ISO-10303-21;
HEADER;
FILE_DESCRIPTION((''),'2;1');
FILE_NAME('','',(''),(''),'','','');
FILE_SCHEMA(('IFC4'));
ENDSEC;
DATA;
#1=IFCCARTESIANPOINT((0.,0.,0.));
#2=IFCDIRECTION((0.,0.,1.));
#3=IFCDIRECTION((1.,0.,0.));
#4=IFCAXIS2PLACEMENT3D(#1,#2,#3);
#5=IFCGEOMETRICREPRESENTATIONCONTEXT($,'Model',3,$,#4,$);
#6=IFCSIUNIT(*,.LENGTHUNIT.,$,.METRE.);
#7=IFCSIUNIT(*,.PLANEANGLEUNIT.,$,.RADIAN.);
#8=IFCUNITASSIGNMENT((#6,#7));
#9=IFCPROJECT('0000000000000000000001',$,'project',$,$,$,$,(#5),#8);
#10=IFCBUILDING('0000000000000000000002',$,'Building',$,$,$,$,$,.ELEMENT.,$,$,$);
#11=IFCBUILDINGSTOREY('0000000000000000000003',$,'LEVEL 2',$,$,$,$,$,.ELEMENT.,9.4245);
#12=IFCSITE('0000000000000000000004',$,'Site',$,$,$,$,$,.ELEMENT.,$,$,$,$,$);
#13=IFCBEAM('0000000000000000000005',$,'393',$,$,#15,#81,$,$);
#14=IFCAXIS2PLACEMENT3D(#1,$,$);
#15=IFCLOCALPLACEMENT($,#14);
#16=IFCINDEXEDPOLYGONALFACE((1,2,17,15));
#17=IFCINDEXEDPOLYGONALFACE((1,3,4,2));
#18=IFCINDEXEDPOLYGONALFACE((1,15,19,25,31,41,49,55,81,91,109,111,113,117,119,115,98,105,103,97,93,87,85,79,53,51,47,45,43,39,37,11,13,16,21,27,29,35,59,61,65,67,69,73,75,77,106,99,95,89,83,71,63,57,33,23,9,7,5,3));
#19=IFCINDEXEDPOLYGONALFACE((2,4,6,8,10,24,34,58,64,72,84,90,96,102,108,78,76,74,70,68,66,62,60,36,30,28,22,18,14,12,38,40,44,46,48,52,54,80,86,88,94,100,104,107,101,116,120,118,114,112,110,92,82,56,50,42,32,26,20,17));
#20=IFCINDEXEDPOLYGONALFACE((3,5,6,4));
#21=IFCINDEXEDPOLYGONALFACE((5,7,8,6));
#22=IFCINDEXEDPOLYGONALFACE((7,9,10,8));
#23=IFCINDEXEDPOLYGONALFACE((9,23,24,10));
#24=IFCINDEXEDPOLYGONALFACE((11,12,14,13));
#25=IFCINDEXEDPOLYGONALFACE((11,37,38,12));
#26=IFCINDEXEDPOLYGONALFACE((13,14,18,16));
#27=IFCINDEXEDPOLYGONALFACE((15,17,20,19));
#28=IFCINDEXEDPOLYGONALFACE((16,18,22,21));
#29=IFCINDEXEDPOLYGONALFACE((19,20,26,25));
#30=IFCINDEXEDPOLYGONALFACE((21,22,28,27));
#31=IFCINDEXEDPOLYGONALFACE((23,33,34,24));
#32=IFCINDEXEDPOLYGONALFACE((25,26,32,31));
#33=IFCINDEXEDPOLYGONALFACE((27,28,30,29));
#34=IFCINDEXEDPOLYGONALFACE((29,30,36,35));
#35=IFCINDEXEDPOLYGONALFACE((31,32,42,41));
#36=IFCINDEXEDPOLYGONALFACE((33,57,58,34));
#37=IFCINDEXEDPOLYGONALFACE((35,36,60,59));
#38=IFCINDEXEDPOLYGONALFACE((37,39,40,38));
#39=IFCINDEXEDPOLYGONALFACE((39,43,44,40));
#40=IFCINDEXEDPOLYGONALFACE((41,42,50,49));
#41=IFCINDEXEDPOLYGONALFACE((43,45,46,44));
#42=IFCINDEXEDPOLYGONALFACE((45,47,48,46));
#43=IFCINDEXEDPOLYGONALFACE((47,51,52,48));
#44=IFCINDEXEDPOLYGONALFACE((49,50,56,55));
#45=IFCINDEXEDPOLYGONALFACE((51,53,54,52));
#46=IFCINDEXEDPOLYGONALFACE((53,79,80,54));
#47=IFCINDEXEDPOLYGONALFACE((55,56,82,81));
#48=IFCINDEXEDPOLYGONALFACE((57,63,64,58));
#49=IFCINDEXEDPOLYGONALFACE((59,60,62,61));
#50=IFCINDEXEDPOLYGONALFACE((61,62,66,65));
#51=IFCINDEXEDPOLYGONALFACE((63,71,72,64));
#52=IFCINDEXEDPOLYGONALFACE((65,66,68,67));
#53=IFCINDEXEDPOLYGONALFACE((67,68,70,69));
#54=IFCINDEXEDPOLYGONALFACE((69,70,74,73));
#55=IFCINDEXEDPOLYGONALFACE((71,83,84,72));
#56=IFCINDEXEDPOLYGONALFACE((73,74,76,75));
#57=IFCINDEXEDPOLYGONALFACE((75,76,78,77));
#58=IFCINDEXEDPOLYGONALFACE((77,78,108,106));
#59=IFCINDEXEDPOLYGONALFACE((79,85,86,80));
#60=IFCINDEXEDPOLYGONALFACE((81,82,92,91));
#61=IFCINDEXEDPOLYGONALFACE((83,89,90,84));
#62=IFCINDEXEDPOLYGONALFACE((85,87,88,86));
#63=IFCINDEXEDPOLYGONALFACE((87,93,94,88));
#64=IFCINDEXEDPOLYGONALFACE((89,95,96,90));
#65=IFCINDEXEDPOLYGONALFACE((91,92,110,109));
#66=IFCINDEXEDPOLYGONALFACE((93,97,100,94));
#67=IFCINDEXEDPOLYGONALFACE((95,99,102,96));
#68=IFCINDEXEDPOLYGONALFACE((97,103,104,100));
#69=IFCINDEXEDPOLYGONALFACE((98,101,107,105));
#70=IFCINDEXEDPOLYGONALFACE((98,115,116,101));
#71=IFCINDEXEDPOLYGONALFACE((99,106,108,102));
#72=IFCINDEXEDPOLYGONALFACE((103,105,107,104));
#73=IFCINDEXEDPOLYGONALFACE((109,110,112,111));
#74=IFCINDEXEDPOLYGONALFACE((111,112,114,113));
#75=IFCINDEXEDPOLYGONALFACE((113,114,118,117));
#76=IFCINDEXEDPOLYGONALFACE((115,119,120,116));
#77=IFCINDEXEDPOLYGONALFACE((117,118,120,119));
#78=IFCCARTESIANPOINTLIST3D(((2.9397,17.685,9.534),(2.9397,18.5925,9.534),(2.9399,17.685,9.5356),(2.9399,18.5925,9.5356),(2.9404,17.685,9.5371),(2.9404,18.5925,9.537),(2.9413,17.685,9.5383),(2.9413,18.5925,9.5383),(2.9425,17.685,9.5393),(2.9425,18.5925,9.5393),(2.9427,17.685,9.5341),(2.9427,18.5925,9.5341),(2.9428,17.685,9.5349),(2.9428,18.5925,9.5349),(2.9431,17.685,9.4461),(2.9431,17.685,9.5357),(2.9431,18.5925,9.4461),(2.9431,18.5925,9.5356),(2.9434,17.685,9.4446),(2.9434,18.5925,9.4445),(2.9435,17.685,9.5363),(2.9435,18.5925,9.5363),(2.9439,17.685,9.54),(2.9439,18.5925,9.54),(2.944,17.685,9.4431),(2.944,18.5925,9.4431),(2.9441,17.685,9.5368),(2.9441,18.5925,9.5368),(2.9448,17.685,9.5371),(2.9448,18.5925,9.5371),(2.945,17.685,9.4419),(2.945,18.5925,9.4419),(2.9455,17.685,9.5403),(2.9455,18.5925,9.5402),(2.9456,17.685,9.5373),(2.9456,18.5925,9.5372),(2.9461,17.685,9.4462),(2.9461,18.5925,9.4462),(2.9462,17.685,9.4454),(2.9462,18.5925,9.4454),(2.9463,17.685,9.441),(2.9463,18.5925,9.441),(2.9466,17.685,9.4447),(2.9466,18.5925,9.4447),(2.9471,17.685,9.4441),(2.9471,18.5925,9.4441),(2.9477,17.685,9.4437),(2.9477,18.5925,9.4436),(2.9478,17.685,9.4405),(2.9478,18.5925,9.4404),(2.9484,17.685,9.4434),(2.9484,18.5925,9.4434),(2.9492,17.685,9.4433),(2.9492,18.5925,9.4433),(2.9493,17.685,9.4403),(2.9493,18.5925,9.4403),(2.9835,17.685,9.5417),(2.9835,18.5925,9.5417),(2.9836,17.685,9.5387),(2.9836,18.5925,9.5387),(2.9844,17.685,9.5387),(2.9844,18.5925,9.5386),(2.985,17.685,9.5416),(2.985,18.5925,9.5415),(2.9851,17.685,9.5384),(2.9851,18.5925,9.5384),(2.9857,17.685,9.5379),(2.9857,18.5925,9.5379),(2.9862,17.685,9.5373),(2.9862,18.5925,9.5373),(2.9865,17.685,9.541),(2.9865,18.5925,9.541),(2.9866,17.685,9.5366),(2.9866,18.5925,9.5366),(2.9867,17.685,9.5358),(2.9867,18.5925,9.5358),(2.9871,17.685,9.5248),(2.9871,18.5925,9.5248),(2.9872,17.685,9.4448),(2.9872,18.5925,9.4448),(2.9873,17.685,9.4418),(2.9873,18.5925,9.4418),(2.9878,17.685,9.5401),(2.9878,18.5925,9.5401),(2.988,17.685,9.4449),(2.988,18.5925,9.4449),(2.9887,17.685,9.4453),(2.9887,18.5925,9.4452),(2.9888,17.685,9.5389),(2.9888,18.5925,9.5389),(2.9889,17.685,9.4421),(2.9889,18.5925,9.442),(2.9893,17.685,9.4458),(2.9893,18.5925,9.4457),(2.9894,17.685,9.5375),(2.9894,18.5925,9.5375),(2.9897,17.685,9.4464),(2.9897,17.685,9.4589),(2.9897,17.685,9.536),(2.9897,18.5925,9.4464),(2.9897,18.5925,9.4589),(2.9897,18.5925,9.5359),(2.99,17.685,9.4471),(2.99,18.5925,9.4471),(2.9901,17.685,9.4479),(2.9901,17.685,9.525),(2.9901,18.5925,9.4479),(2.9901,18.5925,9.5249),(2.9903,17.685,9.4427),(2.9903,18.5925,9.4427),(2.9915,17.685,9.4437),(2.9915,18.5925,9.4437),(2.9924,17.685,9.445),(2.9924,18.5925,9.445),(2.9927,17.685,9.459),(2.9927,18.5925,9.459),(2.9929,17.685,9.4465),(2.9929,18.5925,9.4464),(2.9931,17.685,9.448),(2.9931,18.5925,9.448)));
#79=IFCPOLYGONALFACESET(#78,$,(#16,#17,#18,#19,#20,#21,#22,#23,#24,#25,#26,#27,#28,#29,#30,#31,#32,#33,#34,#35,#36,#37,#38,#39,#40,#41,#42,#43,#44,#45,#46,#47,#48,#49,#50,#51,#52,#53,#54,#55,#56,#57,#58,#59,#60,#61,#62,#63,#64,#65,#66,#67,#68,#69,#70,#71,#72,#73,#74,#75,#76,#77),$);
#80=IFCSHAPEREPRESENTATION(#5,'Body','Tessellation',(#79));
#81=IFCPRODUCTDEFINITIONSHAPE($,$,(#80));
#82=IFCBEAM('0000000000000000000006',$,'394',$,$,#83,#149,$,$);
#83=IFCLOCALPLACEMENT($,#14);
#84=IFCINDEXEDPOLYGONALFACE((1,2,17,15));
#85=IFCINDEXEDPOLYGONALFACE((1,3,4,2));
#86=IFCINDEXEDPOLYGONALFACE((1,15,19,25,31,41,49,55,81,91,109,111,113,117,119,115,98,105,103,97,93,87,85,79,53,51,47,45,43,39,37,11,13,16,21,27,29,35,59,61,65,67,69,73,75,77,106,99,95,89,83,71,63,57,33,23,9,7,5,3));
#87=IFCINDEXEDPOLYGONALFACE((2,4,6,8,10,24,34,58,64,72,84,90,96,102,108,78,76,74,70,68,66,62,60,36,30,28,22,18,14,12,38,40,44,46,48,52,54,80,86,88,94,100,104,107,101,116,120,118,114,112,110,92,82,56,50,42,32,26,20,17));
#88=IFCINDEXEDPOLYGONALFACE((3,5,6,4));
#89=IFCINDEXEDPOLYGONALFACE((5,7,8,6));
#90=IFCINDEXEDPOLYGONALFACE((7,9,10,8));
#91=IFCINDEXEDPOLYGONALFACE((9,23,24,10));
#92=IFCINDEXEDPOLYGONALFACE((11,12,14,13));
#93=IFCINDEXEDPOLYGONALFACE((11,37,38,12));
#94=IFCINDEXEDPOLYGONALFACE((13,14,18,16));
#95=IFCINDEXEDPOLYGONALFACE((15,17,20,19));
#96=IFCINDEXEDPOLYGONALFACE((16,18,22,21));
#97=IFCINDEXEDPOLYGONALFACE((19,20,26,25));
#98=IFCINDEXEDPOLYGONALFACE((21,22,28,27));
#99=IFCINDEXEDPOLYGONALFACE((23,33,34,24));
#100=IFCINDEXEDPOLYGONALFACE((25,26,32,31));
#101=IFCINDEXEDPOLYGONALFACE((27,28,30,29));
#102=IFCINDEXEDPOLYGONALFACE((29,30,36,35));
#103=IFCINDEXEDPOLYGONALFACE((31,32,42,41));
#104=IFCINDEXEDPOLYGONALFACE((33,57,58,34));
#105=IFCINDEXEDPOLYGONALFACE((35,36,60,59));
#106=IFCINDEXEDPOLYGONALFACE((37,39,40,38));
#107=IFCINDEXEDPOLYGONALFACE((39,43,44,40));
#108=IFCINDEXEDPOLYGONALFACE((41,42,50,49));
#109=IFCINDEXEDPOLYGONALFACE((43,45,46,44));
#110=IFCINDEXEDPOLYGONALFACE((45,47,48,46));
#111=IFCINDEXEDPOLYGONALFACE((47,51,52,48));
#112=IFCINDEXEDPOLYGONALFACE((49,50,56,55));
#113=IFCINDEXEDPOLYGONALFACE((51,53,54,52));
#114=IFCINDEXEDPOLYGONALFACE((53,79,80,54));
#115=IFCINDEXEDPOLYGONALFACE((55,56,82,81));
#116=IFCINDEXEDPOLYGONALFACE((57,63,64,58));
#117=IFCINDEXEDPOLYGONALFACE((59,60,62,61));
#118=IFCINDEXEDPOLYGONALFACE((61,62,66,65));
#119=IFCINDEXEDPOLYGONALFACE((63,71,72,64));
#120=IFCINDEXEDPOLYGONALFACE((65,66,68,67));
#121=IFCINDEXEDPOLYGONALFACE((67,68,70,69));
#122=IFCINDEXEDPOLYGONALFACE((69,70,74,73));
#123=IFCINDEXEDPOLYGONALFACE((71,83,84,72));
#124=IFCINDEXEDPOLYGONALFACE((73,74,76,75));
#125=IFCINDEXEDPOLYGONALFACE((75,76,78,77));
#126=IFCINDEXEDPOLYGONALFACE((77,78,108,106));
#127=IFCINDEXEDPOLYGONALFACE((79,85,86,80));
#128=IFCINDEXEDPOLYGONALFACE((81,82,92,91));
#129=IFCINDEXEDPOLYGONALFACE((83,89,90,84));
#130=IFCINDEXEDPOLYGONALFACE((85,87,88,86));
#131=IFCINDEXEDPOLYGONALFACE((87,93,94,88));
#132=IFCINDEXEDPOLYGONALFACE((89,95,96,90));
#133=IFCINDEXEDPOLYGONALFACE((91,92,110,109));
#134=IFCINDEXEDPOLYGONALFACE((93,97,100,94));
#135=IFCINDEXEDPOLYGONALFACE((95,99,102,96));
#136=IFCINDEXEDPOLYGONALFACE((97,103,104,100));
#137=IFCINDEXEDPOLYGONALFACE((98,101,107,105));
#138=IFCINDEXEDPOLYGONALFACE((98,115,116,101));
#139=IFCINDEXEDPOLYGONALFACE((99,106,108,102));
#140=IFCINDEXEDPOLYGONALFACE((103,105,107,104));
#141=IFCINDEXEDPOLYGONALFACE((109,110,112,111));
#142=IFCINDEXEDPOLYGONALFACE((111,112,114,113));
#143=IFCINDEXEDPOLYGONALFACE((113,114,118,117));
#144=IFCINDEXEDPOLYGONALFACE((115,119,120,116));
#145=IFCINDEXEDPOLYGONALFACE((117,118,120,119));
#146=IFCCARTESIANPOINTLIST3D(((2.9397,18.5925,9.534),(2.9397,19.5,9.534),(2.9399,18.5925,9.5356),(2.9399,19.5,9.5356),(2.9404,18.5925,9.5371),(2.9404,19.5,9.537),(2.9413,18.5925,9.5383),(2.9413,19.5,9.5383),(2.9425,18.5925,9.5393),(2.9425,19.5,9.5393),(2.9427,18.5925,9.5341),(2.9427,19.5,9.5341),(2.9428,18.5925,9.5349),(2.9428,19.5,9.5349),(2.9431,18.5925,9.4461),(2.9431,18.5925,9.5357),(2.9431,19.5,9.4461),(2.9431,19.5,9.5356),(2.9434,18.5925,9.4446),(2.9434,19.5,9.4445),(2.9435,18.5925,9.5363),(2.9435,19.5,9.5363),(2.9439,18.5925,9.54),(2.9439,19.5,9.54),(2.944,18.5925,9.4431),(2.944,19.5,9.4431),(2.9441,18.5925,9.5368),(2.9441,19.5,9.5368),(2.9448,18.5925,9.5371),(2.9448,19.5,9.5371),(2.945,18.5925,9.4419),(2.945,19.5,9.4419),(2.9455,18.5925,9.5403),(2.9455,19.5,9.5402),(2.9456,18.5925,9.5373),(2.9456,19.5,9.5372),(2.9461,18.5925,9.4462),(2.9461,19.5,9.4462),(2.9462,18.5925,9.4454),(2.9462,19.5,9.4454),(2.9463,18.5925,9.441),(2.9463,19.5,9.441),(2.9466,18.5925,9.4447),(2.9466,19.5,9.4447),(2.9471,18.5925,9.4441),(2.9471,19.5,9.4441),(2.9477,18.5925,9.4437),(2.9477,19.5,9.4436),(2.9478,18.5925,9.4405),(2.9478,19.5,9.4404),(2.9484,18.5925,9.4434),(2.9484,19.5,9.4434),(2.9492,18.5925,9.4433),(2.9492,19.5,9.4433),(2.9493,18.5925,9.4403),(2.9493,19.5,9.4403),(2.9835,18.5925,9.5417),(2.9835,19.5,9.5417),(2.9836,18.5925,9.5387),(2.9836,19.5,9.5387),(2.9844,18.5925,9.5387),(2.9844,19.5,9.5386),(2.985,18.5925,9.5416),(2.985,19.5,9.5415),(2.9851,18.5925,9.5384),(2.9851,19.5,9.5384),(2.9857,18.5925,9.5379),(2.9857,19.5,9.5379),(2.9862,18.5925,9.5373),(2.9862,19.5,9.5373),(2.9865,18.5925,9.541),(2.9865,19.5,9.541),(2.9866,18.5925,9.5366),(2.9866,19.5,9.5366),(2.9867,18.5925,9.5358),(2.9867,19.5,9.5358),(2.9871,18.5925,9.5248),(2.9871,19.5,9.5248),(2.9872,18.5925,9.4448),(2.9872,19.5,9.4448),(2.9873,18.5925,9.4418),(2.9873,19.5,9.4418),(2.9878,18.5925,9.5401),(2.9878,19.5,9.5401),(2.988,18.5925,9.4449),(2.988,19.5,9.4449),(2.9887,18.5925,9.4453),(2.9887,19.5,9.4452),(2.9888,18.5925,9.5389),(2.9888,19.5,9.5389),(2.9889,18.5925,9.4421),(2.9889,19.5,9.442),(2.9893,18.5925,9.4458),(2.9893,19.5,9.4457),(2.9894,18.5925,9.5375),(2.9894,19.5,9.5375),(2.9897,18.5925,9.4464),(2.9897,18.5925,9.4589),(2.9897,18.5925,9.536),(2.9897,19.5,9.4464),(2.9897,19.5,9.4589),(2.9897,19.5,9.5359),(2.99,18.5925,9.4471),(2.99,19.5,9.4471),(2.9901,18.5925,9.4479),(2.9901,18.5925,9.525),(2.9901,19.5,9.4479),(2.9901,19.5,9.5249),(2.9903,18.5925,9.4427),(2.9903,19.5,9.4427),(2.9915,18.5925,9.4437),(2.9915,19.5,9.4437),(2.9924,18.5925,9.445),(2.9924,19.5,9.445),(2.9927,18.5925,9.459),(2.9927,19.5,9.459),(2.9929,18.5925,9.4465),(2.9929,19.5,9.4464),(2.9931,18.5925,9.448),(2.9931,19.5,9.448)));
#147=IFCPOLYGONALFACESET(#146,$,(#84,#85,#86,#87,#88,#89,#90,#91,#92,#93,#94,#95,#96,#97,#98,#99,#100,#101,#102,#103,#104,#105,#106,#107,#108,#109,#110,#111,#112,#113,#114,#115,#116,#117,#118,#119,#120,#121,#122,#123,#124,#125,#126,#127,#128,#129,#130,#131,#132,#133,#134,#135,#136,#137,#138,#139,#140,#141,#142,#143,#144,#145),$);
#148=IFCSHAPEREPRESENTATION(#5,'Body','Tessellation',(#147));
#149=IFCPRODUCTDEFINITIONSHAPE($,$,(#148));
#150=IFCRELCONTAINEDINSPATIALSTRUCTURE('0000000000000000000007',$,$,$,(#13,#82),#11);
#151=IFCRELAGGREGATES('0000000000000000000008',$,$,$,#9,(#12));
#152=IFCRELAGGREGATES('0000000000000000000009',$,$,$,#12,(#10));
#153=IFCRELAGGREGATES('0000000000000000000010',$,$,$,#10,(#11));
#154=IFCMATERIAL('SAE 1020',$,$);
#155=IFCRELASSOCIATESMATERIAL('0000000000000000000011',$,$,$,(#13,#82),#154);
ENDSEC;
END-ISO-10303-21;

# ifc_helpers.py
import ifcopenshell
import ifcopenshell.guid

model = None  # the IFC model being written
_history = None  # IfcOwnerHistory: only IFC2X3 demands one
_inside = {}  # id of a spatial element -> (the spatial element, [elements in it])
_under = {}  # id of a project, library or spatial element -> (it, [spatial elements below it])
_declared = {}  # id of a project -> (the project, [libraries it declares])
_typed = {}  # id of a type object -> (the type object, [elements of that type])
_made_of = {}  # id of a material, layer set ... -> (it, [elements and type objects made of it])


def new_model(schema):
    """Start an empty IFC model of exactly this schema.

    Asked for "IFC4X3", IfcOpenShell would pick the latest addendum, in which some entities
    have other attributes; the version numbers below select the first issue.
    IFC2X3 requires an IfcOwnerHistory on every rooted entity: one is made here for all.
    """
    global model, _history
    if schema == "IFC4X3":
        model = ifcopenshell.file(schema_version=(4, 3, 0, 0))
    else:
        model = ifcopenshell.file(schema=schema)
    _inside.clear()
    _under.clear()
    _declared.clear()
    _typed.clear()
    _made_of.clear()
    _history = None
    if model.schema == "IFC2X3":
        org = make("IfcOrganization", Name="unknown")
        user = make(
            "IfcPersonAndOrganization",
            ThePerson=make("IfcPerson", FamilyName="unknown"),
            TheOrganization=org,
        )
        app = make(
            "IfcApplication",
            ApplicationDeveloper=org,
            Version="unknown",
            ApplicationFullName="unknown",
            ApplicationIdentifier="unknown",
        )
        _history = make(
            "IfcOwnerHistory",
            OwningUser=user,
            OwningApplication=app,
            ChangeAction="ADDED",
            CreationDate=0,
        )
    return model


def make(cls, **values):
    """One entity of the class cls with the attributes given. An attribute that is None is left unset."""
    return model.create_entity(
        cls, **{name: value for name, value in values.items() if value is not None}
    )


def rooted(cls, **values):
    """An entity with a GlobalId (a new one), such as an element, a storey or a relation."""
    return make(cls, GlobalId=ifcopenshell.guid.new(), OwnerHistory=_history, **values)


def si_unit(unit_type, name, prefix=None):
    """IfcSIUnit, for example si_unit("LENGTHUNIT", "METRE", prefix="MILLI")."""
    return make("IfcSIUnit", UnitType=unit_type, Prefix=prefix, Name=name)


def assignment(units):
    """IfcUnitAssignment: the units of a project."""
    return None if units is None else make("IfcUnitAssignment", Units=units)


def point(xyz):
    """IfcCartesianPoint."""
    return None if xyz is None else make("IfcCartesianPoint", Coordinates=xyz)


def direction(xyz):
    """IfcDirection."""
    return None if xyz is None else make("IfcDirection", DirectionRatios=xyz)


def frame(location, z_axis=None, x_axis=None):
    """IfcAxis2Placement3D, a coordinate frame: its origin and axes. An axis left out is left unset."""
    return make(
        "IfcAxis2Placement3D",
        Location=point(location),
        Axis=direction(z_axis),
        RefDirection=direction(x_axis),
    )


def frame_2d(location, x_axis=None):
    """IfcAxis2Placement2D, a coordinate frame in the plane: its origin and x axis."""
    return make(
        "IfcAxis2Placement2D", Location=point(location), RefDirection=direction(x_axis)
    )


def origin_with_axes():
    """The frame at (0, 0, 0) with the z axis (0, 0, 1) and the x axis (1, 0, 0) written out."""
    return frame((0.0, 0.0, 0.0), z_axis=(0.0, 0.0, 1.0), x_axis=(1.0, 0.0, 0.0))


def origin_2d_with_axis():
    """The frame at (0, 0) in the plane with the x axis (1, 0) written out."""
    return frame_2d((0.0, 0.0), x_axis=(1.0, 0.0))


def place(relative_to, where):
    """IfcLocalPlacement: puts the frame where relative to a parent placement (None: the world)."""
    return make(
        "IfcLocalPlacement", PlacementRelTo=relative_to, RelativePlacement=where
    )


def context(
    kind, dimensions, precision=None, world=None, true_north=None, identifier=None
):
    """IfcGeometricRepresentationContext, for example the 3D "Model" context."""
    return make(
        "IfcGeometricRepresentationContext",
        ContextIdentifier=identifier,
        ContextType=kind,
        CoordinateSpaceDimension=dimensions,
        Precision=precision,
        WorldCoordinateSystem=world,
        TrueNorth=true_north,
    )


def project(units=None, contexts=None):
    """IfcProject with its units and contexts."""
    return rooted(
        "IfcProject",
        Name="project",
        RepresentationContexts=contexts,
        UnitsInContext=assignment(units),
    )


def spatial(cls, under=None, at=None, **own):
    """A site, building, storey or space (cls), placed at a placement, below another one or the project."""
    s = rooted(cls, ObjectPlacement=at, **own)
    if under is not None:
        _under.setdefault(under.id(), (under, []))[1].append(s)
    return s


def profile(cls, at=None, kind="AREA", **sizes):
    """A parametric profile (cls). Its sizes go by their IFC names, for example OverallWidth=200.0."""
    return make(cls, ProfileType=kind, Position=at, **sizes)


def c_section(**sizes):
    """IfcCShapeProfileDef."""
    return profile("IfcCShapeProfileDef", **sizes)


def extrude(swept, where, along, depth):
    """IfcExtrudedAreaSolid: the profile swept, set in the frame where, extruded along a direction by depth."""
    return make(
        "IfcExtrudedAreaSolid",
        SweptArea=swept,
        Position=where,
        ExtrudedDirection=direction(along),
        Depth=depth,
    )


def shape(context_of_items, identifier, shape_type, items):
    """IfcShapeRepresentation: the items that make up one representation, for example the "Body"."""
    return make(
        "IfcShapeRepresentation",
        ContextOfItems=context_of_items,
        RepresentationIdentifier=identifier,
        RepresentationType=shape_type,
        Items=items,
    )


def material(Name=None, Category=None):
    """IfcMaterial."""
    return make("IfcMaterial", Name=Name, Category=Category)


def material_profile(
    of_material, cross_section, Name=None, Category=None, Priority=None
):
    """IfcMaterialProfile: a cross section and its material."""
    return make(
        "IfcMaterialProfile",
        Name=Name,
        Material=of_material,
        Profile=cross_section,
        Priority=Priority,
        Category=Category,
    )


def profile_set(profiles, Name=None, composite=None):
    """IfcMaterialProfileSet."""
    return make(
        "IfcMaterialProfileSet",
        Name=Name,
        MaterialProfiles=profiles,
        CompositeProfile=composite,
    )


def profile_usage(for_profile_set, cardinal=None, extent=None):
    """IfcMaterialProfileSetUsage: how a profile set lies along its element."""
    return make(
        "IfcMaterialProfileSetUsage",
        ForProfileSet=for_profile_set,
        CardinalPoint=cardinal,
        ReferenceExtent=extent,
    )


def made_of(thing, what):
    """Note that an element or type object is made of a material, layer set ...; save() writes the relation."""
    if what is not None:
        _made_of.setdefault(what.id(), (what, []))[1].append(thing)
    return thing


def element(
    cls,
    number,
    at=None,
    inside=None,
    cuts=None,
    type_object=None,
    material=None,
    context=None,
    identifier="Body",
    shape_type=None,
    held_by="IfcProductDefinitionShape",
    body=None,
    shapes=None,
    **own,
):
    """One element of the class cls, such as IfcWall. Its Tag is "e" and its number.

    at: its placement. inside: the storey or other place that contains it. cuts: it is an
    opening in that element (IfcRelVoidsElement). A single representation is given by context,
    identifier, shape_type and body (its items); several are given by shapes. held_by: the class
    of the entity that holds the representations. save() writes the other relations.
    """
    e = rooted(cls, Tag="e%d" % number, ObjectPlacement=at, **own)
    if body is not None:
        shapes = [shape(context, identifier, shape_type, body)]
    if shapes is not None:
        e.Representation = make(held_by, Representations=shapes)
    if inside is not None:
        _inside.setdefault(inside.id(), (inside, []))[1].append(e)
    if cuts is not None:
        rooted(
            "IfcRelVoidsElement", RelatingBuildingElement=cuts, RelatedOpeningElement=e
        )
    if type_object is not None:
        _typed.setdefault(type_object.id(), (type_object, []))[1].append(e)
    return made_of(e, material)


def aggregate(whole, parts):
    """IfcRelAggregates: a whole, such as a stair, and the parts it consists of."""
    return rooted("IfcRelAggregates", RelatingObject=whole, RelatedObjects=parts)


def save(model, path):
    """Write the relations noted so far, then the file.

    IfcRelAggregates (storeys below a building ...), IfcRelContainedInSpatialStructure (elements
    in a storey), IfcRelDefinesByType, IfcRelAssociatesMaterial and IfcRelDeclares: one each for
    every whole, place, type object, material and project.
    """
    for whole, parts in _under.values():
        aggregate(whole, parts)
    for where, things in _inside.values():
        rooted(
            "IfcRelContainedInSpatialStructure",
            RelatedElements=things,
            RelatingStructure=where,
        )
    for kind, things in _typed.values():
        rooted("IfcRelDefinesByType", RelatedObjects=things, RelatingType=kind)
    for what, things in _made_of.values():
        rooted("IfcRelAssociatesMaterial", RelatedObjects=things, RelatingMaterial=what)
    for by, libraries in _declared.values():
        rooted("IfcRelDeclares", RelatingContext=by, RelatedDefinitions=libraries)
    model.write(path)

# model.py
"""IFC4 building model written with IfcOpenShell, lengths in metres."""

from ifc_helpers import new_model, si_unit, frame, origin_with_axes, origin_2d_with_axis, place, context, project, spatial, c_section, extrude, material, material_profile, profile_set, profile_usage, element, save


model = new_model("IFC4")

# Units and contexts
model_context = context("Model", 3, world=origin_with_axes())
ifc_project = project(units=[si_unit("LENGTHUNIT", "METRE"), si_unit("PLANEANGLEUNIT", "RADIAN")], contexts=[model_context])

# Site, building, storey
site = spatial("IfcSite", under=ifc_project, Name="Site", CompositionType="ELEMENT")
building = spatial("IfcBuilding", under=site, Name="Building", CompositionType="ELEMENT")
storey = spatial("IfcBuildingStorey", under=building, Name="LEVEL 2", CompositionType="ELEMENT", Elevation=9.4245)

# Beams
ifc_material = material(Name="SAE 1020")
ifc_material_profile_1 = material_profile(ifc_material, c_section(Depth=0.1, Width=0.05, WallThickness=0.003, Girth=0.017, InternalFilletRadius=0.003, at=origin_2d_with_axis()))
ifc_profile_set_1 = profile_set([ifc_material_profile_1])
ifc_profile_usage_1 = profile_usage(ifc_profile_set_1, cardinal=10)
beam_1_placement = place(None, frame((2.9664, 17.685, 9.491), z_axis=(0.0, 1.0, -0.00003), x_axis=(0.999256, 0.000001, 0.038562)))
element("IfcBeam", 1, at=beam_1_placement, inside=storey, material=ifc_profile_usage_1, Name="393", context=model_context, shape_type="SweptSolid", body=[
    extrude(c_section(Depth=0.1, Width=0.05, WallThickness=0.003, Girth=0.017, InternalFilletRadius=0.003, at=origin_2d_with_axis()), origin_with_axes(), (0.0, 0.0, 1.0), 0.9075),
])
ifc_material_profile_2 = material_profile(ifc_material, c_section(Depth=0.1, Width=0.05, WallThickness=0.003, Girth=0.017, InternalFilletRadius=0.003, at=origin_2d_with_axis()))
ifc_profile_set_2 = profile_set([ifc_material_profile_2])
ifc_profile_usage_2 = profile_usage(ifc_profile_set_2, cardinal=10)
beam_2_placement = place(None, frame((2.9664, 18.5925, 9.491), z_axis=(0.0, 1.0, -0.00003), x_axis=(0.999256, 0.000001, 0.038562)))
element("IfcBeam", 2, at=beam_2_placement, inside=storey, material=ifc_profile_usage_2, Name="394", context=model_context, shape_type="SweptSolid", body=[
    extrude(c_section(Depth=0.1, Width=0.05, WallThickness=0.003, Girth=0.017, InternalFilletRadius=0.003, at=origin_2d_with_axis()), origin_with_axes(), (0.0, 0.0, 1.0), 0.9075),
])

save(model, "model.ifc")
